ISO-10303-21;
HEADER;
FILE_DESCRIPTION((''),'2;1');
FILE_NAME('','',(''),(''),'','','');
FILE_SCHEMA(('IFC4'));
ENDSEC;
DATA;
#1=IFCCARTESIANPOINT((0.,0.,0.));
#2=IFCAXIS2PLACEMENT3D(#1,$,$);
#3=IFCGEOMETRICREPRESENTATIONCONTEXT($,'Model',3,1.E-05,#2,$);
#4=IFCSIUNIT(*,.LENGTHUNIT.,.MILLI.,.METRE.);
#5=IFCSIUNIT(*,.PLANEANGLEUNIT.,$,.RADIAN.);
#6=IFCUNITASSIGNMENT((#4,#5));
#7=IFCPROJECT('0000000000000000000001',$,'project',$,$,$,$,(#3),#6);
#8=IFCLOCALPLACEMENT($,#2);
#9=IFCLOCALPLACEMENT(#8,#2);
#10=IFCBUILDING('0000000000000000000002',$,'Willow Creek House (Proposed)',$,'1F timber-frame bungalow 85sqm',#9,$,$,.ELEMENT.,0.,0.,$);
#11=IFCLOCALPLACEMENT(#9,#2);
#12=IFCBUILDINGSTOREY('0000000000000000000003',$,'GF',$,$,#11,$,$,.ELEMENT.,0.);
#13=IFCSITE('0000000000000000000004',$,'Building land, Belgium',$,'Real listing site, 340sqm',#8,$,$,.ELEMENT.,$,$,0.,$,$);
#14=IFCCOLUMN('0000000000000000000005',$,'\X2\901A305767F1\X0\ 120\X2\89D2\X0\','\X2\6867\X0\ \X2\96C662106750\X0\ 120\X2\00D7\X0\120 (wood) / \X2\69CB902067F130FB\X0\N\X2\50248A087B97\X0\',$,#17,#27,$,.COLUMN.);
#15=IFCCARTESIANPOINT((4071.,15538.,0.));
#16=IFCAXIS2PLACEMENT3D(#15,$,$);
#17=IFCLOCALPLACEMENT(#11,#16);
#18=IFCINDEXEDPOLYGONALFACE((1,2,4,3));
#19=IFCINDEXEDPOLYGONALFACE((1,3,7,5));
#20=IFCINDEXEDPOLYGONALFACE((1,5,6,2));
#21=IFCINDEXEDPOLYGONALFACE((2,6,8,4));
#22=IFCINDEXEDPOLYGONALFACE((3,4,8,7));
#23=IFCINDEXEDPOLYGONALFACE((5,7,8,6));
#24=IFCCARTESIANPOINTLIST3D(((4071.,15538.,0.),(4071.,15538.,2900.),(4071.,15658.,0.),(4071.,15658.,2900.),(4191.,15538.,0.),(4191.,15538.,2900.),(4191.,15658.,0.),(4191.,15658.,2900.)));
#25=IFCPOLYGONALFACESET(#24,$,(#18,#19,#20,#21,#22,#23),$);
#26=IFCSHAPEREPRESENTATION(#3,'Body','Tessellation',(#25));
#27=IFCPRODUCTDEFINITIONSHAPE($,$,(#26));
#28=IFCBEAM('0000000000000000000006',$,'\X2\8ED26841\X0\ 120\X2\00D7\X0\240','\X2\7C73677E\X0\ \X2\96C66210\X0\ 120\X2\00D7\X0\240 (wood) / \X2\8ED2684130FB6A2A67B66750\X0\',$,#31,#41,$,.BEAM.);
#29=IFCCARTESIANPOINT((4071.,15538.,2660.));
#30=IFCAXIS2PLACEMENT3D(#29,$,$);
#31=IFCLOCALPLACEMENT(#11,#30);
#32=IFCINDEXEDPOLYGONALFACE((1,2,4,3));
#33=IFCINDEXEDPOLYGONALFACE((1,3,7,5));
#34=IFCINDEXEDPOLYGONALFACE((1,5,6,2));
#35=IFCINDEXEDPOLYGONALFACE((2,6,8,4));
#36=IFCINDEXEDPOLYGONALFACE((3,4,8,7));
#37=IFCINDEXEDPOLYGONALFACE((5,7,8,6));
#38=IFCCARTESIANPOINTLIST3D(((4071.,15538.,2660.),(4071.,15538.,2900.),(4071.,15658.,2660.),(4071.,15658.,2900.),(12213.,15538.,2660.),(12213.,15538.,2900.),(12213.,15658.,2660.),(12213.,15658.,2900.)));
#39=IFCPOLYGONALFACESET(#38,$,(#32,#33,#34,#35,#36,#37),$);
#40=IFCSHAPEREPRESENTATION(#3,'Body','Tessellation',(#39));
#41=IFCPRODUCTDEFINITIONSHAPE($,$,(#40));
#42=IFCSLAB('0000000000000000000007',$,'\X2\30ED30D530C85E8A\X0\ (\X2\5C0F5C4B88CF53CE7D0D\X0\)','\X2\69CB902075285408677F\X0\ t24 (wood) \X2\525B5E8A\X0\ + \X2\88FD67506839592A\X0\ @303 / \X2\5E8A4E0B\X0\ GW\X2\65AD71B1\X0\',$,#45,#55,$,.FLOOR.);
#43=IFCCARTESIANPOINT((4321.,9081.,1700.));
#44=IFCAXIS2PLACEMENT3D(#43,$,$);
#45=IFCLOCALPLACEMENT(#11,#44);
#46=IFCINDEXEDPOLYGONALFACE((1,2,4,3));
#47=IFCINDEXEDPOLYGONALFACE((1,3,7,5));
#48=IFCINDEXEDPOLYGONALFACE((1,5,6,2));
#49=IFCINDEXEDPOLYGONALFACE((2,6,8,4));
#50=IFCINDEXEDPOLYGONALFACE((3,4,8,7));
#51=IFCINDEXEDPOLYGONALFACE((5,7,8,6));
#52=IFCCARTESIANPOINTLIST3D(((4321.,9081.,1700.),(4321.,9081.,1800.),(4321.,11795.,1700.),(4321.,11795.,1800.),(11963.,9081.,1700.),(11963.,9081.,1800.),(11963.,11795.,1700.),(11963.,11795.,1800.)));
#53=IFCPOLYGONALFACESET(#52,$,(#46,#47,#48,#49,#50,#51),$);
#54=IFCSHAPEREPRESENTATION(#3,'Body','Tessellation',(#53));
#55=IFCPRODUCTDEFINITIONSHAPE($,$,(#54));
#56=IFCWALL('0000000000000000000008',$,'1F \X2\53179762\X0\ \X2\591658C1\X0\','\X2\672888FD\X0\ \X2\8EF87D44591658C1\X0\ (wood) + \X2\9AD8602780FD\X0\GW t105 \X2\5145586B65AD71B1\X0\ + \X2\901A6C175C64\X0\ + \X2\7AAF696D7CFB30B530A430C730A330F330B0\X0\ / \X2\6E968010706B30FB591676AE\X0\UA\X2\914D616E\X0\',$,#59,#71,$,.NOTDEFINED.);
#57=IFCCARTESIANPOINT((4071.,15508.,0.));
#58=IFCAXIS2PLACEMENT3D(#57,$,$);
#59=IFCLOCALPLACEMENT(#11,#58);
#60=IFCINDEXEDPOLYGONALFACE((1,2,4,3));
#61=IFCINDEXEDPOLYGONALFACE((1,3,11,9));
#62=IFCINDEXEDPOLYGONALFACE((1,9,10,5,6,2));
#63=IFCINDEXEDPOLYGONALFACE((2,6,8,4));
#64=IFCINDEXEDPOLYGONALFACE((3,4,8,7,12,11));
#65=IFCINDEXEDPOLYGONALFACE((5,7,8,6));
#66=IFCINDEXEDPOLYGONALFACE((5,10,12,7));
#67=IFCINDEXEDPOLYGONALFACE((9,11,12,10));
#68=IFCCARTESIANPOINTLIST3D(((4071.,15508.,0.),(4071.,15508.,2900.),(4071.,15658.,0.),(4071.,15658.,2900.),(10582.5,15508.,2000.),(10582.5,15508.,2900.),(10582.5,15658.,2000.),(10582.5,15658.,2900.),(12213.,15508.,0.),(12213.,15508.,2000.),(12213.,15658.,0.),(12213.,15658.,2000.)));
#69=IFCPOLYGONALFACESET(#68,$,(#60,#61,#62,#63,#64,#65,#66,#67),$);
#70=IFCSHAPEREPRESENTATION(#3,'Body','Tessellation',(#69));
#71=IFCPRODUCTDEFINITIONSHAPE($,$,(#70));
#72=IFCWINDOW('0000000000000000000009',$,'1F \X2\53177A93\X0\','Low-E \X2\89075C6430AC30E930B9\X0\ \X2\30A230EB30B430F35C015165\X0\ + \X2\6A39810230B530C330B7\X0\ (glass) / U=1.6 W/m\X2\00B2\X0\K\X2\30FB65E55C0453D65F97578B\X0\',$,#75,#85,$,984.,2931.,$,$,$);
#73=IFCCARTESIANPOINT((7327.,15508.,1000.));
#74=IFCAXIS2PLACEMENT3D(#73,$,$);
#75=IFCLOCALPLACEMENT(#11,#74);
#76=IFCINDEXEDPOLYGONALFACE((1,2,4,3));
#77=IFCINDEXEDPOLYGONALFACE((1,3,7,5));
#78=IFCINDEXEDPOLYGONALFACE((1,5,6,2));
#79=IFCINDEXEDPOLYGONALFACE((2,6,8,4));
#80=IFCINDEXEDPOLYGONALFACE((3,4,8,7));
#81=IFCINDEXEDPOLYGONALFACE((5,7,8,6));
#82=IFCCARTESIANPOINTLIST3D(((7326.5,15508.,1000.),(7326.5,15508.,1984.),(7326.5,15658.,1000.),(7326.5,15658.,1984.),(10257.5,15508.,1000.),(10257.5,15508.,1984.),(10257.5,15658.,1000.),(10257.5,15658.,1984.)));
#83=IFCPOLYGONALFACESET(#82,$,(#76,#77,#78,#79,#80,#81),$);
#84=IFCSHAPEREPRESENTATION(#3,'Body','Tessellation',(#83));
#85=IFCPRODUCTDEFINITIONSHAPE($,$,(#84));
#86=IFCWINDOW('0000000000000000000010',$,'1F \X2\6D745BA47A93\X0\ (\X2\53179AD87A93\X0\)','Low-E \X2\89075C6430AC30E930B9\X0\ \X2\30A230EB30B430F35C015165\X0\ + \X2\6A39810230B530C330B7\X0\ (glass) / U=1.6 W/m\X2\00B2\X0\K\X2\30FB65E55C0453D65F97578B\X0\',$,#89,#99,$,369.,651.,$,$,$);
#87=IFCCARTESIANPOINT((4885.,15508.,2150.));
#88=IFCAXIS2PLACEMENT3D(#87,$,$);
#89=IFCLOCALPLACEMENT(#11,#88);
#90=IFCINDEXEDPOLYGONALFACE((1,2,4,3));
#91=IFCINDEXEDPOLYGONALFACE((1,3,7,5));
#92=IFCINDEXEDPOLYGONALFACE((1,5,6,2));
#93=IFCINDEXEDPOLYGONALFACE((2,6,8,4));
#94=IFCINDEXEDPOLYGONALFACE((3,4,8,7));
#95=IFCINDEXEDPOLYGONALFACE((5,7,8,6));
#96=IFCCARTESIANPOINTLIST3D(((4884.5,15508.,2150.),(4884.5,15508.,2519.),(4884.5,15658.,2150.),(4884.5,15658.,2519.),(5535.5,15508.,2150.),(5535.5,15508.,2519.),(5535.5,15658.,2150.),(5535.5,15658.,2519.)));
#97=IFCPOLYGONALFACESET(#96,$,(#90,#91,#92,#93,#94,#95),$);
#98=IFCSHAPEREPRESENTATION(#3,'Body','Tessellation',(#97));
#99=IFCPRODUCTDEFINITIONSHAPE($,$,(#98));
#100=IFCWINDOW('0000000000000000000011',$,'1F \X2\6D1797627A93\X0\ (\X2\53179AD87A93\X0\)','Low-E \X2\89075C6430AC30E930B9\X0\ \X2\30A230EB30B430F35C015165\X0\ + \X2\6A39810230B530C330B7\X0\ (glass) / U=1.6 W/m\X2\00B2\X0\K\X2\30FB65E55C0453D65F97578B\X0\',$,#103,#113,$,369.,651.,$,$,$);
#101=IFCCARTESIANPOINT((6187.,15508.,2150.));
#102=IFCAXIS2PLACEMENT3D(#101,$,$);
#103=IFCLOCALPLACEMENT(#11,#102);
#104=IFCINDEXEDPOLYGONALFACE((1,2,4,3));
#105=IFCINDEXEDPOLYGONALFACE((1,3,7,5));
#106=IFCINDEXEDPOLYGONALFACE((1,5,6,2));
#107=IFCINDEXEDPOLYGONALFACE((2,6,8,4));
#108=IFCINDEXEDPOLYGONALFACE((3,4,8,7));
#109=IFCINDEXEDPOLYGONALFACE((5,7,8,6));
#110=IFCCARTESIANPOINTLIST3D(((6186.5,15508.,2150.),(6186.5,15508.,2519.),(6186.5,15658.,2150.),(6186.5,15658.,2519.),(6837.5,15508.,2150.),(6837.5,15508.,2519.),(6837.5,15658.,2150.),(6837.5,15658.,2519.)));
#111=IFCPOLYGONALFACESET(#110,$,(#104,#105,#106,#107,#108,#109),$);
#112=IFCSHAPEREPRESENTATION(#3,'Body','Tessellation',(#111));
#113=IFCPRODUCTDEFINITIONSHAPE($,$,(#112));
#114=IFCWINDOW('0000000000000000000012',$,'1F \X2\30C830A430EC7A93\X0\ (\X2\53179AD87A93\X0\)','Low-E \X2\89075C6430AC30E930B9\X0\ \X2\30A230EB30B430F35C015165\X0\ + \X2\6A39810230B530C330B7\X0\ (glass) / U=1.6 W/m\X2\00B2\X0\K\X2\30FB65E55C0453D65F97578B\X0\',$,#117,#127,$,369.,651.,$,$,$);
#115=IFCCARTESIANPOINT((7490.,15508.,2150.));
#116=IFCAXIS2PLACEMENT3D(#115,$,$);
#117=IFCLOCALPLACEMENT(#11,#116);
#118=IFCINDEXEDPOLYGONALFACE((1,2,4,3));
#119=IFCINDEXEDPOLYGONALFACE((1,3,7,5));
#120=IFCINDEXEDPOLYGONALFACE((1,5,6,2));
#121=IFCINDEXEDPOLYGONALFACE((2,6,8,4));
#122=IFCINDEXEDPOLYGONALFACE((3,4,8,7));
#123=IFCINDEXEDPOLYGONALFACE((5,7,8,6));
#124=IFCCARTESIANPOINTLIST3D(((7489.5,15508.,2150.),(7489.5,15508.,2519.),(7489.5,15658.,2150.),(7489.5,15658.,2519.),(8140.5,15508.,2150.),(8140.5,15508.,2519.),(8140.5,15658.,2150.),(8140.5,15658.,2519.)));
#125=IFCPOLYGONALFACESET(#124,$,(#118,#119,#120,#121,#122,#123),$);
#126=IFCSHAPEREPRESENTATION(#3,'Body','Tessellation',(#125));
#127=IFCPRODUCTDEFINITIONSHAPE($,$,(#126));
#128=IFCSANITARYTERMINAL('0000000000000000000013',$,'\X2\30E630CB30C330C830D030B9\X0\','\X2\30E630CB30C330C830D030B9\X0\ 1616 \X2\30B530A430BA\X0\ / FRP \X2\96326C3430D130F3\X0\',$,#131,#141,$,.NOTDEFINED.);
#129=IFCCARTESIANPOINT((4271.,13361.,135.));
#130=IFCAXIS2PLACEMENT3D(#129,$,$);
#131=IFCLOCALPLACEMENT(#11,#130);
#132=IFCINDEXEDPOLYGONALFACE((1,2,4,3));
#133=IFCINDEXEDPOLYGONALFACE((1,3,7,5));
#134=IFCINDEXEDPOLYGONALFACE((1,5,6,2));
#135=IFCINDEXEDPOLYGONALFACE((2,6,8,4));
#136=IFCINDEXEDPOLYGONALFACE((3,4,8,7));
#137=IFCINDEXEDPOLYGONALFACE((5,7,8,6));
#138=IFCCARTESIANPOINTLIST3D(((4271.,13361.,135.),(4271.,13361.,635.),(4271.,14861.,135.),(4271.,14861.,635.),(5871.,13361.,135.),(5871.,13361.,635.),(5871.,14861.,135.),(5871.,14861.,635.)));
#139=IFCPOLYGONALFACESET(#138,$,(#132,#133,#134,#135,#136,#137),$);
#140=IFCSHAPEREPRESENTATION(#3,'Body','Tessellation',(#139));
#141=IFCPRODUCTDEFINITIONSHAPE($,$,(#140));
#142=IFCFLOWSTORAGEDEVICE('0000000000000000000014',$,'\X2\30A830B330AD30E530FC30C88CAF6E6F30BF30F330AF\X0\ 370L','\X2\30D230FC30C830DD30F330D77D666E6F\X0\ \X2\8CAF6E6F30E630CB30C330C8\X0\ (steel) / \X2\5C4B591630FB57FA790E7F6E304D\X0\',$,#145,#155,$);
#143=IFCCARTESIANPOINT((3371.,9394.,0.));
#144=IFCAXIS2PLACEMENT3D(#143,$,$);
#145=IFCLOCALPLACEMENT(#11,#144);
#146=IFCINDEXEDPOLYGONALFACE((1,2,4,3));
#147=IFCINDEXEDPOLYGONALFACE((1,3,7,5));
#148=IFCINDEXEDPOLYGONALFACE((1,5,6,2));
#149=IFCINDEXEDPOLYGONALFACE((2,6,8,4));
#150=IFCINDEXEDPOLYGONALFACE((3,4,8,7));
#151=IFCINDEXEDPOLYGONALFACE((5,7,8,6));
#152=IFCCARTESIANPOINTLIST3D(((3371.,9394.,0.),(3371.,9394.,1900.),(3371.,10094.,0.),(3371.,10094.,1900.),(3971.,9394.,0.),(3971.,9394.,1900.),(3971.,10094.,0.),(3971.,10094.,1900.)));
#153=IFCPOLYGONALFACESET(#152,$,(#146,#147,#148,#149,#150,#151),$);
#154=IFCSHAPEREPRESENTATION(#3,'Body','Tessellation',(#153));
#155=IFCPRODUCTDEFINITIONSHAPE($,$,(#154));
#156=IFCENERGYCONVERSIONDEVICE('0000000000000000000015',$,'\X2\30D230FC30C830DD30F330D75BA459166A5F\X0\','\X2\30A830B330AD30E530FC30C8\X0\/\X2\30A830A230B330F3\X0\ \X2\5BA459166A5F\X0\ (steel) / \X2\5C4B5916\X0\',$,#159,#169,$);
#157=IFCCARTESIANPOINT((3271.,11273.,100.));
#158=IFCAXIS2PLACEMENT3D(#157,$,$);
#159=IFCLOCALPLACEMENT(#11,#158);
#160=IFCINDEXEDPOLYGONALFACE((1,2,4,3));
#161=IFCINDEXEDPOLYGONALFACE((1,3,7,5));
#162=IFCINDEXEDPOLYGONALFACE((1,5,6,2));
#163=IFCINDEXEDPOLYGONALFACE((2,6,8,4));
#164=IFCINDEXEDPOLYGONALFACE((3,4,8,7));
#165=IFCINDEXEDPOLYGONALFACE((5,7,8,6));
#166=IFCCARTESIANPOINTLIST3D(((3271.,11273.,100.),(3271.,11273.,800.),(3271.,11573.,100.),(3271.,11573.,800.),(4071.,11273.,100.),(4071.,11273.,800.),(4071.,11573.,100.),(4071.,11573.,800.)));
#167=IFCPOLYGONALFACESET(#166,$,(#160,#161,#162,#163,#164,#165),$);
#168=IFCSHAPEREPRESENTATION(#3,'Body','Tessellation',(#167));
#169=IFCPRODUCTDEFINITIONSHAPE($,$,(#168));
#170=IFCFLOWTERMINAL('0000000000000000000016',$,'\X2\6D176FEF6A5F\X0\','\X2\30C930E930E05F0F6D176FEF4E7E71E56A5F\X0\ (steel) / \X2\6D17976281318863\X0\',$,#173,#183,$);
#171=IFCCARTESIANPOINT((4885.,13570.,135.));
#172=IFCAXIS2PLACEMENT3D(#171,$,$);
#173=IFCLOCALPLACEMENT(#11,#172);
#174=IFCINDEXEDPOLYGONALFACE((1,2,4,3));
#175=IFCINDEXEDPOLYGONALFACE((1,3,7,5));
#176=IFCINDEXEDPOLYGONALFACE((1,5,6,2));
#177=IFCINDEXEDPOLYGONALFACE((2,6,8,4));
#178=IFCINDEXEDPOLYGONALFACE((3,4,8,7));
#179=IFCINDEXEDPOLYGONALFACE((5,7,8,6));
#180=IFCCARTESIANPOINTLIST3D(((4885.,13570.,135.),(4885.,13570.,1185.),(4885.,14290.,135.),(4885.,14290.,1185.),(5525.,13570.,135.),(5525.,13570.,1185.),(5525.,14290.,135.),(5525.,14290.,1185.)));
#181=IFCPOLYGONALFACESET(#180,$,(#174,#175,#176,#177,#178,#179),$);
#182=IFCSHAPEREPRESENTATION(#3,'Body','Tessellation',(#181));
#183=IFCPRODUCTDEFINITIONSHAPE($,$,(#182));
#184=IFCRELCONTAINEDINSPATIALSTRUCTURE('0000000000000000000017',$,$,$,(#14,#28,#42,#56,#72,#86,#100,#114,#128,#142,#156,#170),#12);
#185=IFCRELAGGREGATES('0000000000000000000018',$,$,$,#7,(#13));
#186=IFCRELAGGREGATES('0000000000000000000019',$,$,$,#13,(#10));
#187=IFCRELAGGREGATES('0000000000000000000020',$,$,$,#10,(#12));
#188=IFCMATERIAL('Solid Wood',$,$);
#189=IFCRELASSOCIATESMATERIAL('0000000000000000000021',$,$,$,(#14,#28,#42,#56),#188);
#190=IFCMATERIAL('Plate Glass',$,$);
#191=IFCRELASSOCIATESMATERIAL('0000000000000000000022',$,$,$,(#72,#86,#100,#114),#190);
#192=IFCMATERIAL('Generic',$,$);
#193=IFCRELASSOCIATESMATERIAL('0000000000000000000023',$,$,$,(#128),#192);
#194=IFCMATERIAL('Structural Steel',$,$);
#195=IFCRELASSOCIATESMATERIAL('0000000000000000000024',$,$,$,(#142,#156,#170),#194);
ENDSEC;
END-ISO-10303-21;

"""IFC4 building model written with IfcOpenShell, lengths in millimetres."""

from ifc_helpers import new_model, si_unit, frame, frame_2d, origin, place, context, project, spatial, rectangle, extrude, material, element, fill, save


model = new_model("IFC4")

# Units and contexts
model_context = context("Model", 3, precision=1e-05, world=origin())
ifc_project = project(units=[si_unit("LENGTHUNIT", "METRE", prefix="MILLI"), si_unit("PLANEANGLEUNIT", "RADIAN")], contexts=[model_context])

# Site, building, storey
site_placement = place(None, origin())
site = spatial("IfcSite", under=ifc_project, at=site_placement, Name="Building land, Belgium", ObjectType="Real listing site, 340sqm", CompositionType="ELEMENT", RefElevation=0.0)
building_placement = place(site_placement, origin())
building = spatial("IfcBuilding", under=site, at=building_placement, Name="Willow Creek House (Proposed)", ObjectType="1F timber-frame bungalow 85sqm", CompositionType="ELEMENT", ElevationOfRefHeight=0.0, ElevationOfTerrain=0.0)
storey_placement = place(building_placement, origin())
storey = spatial("IfcBuildingStorey", under=building, at=storey_placement, Name="GF", CompositionType="ELEMENT", Elevation=0.0)

# Column
ifc_material_1 = material(Name="Solid Wood")
column_1_placement = place(storey_placement, frame((4071.0, 15538.0, 0.0)))
element("IfcColumn", 1, at=column_1_placement, inside=storey, material=ifc_material_1, Name="通し柱 120角", Description="桧 集成材 120×120 (wood) / 構造柱・N値計算", PredefinedType="COLUMN", context=model_context, shape_type="SweptSolid", body=[
    extrude(rectangle(XDim=120.0, YDim=120.0, at=frame_2d((60.0, 60.0))), frame((4071.0, 15538.0, 0.0)), (0.0, 0.0, 1.0), 2900.0),
])

# Beam
beam_1_placement = place(storey_placement, frame((4071.0, 15538.0, 2660.0)))
element("IfcBeam", 2, at=beam_1_placement, inside=storey, material=ifc_material_1, Name="軒桁 120×240", Description="米松 集成 120×240 (wood) / 軒桁・横架材", PredefinedType="BEAM", context=model_context, shape_type="SweptSolid", body=[
    extrude(rectangle(XDim=8142.0, YDim=120.0, at=frame_2d((4071.0, 60.0))), frame((4071.0, 15538.0, 2660.0)), (0.0, 0.0, 1.0), 240.0),
])

# Slab
slab_placement = place(storey_placement, frame((4321.0, 9081.0, 1700.0)))
element("IfcSlab", 3, at=slab_placement, inside=storey, material=ifc_material_1, Name="ロフト床 (小屋裏収納)", Description="構造用合板 t24 (wood) 剛床 + 製材根太 @303 / 床下 GW断熱", PredefinedType="FLOOR", context=model_context, shape_type="SweptSolid", body=[
    extrude(rectangle(XDim=7642.0, YDim=2714.0, at=frame_2d((3821.0, 1357.0))), frame((4321.0, 9081.0, 1700.0)), (0.0, 0.0, 1.0), 100.0),
])

# Wall, openings, windows
wall_1_placement = place(storey_placement, frame((4071.0, 15508.0, 0.0)))
wall_1 = element("IfcWall", 4, at=wall_1_placement, inside=storey, material=ifc_material_1, Name="1F 北面 外壁", Description="木製 軸組外壁 (wood) + 高性能GW t105 充填断熱 + 通気層 + 窯業系サイディング / 準耐火・外皮UA配慮", PredefinedType="NOTDEFINED", context=model_context, shape_type="SweptSolid", body=[
    extrude(rectangle(XDim=8142.0, YDim=150.0, at=frame_2d((4071.0, 75.0))), frame((4071.0, 15508.0, 0.0)), (0.0, 0.0, 1.0), 2900.0),
])
opening_1_placement = place(storey_placement, frame((7327.0, 15508.0, 1000.0)))
opening_1 = element("IfcOpeningElement", 5, at=opening_1_placement, cuts=wall_1, PredefinedType="NOTDEFINED", context=model_context, shape_type="SweptSolid", body=[
    extrude(rectangle(XDim=2931.0, YDim=150.0, at=frame_2d((1465.0, 75.0))), frame((7327.0, 15508.0, 1000.0)), (0.0, 0.0, 1.0), 984.0),
])
opening_2_placement = place(storey_placement, frame((4885.0, 15508.0, 2150.0)))
opening_2 = element("IfcOpeningElement", 6, at=opening_2_placement, cuts=wall_1, PredefinedType="NOTDEFINED", context=model_context, shape_type="SweptSolid", body=[
    extrude(rectangle(XDim=651.0, YDim=150.0, at=frame_2d((325.0, 75.0))), frame((4885.0, 15508.0, 2150.0)), (0.0, 0.0, 1.0), 369.0),
])
opening_3_placement = place(storey_placement, frame((6187.0, 15508.0, 2150.0)))
opening_3 = element("IfcOpeningElement", 7, at=opening_3_placement, cuts=wall_1, PredefinedType="NOTDEFINED", context=model_context, shape_type="SweptSolid", body=[
    extrude(rectangle(XDim=651.0, YDim=150.0, at=frame_2d((325.0, 75.0))), frame((6187.0, 15508.0, 2150.0)), (0.0, 0.0, 1.0), 369.0),
])
opening_4_placement = place(storey_placement, frame((7490.0, 15508.0, 2150.0)))
opening_4 = element("IfcOpeningElement", 8, at=opening_4_placement, cuts=wall_1, PredefinedType="NOTDEFINED", context=model_context, shape_type="SweptSolid", body=[
    extrude(rectangle(XDim=651.0, YDim=150.0, at=frame_2d((325.0, 75.0))), frame((7490.0, 15508.0, 2150.0)), (0.0, 0.0, 1.0), 369.0),
])
ifc_material_2 = material(Name="Plate Glass")
window_1_placement = place(storey_placement, frame((7327.0, 15508.0, 1000.0)))
window_1 = element("IfcWindow", 9, at=window_1_placement, inside=storey, material=ifc_material_2, Name="1F 北窓", Description="Low-E 複層ガラス アルゴン封入 + 樹脂サッシ (glass) / U=1.6 W/m²K・日射取得型", OverallHeight=984.0, OverallWidth=2931.0, context=model_context, shape_type="SweptSolid", body=[
    extrude(rectangle(XDim=2931.0, YDim=150.0, at=frame_2d((1465.0, 75.0))), frame((7327.0, 15508.0, 1000.0)), (0.0, 0.0, 1.0), 984.0),
])
fill(opening_1, window_1)
window_2_placement = place(storey_placement, frame((4885.0, 15508.0, 2150.0)))
window_2 = element("IfcWindow", 10, at=window_2_placement, inside=storey, material=ifc_material_2, Name="1F 浴室窓 (北高窓)", Description="Low-E 複層ガラス アルゴン封入 + 樹脂サッシ (glass) / U=1.6 W/m²K・日射取得型", OverallHeight=369.0, OverallWidth=651.0, context=model_context, shape_type="SweptSolid", body=[
    extrude(rectangle(XDim=651.0, YDim=150.0, at=frame_2d((325.0, 75.0))), frame((4885.0, 15508.0, 2150.0)), (0.0, 0.0, 1.0), 369.0),
])
fill(opening_2, window_2)
window_3_placement = place(storey_placement, frame((6187.0, 15508.0, 2150.0)))
window_3 = element("IfcWindow", 11, at=window_3_placement, inside=storey, material=ifc_material_2, Name="1F 洗面窓 (北高窓)", Description="Low-E 複層ガラス アルゴン封入 + 樹脂サッシ (glass) / U=1.6 W/m²K・日射取得型", OverallHeight=369.0, OverallWidth=651.0, context=model_context, shape_type="SweptSolid", body=[
    extrude(rectangle(XDim=651.0, YDim=150.0, at=frame_2d((325.0, 75.0))), frame((6187.0, 15508.0, 2150.0)), (0.0, 0.0, 1.0), 369.0),
])
fill(opening_3, window_3)
window_4_placement = place(storey_placement, frame((7490.0, 15508.0, 2150.0)))
window_4 = element("IfcWindow", 12, at=window_4_placement, inside=storey, material=ifc_material_2, Name="1F トイレ窓 (北高窓)", Description="Low-E 複層ガラス アルゴン封入 + 樹脂サッシ (glass) / U=1.6 W/m²K・日射取得型", OverallHeight=369.0, OverallWidth=651.0, context=model_context, shape_type="SweptSolid", body=[
    extrude(rectangle(XDim=651.0, YDim=150.0, at=frame_2d((325.0, 75.0))), frame((7490.0, 15508.0, 2150.0)), (0.0, 0.0, 1.0), 369.0),
])
fill(opening_4, window_4)

# Sanitary terminal
ifc_material_3 = material(Name="Generic")
sanitary_terminal_placement = place(storey_placement, frame((4271.0, 13361.0, 135.0)))
element("IfcSanitaryTerminal", 13, at=sanitary_terminal_placement, inside=storey, material=ifc_material_3, Name="ユニットバス", Description="ユニットバス 1616 サイズ / FRP 防水パン", PredefinedType="NOTDEFINED", context=model_context, shape_type="SweptSolid", body=[
    extrude(rectangle(XDim=1600.0, YDim=1500.0, at=frame_2d((800.0, 750.0))), frame((4271.0, 13361.0, 135.0)), (0.0, 0.0, 1.0), 500.0),
])

# Flow storage device
ifc_material_4 = material(Name="Structural Steel")
flow_storage_device_placement = place(storey_placement, frame((3371.0, 9394.0, 0.0)))
element("IfcFlowStorageDevice", 14, at=flow_storage_device_placement, inside=storey, material=ifc_material_4, Name="エコキュート貯湯タンク 370L", Description="ヒートポンプ給湯 貯湯ユニット (steel) / 屋外・基礎置き", context=model_context, shape_type="SweptSolid", body=[
    extrude(rectangle(XDim=600.0, YDim=700.0, at=frame_2d((300.0, 350.0))), frame((3371.0, 9394.0, 0.0)), (0.0, 0.0, 1.0), 1900.0),
])

# Energy conversion device
energy_conversion_device_placement = place(storey_placement, frame((3271.0, 11273.0, 100.0)))
element("IfcEnergyConversionDevice", 15, at=energy_conversion_device_placement, inside=storey, material=ifc_material_4, Name="ヒートポンプ室外機", Description="エコキュート/エアコン 室外機 (steel) / 屋外", context=model_context, shape_type="SweptSolid", body=[
    extrude(rectangle(XDim=800.0, YDim=300.0, at=frame_2d((400.0, 150.0))), frame((3271.0, 11273.0, 100.0)), (0.0, 0.0, 1.0), 700.0),
])

# Flow terminal
flow_terminal_placement = place(storey_placement, frame((4885.0, 13570.0, 135.0)))
element("IfcFlowTerminal", 16, at=flow_terminal_placement, inside=storey, material=ifc_material_4, Name="洗濯機", Description="ドラム式洗濯乾燥機 (steel) / 洗面脱衣", context=model_context, shape_type="SweptSolid", body=[
    extrude(rectangle(XDim=640.0, YDim=720.0, at=frame_2d((320.0, 360.0))), frame((4885.0, 13570.0, 135.0)), (0.0, 0.0, 1.0), 1050.0),
])

save(model, "model.ifc")
